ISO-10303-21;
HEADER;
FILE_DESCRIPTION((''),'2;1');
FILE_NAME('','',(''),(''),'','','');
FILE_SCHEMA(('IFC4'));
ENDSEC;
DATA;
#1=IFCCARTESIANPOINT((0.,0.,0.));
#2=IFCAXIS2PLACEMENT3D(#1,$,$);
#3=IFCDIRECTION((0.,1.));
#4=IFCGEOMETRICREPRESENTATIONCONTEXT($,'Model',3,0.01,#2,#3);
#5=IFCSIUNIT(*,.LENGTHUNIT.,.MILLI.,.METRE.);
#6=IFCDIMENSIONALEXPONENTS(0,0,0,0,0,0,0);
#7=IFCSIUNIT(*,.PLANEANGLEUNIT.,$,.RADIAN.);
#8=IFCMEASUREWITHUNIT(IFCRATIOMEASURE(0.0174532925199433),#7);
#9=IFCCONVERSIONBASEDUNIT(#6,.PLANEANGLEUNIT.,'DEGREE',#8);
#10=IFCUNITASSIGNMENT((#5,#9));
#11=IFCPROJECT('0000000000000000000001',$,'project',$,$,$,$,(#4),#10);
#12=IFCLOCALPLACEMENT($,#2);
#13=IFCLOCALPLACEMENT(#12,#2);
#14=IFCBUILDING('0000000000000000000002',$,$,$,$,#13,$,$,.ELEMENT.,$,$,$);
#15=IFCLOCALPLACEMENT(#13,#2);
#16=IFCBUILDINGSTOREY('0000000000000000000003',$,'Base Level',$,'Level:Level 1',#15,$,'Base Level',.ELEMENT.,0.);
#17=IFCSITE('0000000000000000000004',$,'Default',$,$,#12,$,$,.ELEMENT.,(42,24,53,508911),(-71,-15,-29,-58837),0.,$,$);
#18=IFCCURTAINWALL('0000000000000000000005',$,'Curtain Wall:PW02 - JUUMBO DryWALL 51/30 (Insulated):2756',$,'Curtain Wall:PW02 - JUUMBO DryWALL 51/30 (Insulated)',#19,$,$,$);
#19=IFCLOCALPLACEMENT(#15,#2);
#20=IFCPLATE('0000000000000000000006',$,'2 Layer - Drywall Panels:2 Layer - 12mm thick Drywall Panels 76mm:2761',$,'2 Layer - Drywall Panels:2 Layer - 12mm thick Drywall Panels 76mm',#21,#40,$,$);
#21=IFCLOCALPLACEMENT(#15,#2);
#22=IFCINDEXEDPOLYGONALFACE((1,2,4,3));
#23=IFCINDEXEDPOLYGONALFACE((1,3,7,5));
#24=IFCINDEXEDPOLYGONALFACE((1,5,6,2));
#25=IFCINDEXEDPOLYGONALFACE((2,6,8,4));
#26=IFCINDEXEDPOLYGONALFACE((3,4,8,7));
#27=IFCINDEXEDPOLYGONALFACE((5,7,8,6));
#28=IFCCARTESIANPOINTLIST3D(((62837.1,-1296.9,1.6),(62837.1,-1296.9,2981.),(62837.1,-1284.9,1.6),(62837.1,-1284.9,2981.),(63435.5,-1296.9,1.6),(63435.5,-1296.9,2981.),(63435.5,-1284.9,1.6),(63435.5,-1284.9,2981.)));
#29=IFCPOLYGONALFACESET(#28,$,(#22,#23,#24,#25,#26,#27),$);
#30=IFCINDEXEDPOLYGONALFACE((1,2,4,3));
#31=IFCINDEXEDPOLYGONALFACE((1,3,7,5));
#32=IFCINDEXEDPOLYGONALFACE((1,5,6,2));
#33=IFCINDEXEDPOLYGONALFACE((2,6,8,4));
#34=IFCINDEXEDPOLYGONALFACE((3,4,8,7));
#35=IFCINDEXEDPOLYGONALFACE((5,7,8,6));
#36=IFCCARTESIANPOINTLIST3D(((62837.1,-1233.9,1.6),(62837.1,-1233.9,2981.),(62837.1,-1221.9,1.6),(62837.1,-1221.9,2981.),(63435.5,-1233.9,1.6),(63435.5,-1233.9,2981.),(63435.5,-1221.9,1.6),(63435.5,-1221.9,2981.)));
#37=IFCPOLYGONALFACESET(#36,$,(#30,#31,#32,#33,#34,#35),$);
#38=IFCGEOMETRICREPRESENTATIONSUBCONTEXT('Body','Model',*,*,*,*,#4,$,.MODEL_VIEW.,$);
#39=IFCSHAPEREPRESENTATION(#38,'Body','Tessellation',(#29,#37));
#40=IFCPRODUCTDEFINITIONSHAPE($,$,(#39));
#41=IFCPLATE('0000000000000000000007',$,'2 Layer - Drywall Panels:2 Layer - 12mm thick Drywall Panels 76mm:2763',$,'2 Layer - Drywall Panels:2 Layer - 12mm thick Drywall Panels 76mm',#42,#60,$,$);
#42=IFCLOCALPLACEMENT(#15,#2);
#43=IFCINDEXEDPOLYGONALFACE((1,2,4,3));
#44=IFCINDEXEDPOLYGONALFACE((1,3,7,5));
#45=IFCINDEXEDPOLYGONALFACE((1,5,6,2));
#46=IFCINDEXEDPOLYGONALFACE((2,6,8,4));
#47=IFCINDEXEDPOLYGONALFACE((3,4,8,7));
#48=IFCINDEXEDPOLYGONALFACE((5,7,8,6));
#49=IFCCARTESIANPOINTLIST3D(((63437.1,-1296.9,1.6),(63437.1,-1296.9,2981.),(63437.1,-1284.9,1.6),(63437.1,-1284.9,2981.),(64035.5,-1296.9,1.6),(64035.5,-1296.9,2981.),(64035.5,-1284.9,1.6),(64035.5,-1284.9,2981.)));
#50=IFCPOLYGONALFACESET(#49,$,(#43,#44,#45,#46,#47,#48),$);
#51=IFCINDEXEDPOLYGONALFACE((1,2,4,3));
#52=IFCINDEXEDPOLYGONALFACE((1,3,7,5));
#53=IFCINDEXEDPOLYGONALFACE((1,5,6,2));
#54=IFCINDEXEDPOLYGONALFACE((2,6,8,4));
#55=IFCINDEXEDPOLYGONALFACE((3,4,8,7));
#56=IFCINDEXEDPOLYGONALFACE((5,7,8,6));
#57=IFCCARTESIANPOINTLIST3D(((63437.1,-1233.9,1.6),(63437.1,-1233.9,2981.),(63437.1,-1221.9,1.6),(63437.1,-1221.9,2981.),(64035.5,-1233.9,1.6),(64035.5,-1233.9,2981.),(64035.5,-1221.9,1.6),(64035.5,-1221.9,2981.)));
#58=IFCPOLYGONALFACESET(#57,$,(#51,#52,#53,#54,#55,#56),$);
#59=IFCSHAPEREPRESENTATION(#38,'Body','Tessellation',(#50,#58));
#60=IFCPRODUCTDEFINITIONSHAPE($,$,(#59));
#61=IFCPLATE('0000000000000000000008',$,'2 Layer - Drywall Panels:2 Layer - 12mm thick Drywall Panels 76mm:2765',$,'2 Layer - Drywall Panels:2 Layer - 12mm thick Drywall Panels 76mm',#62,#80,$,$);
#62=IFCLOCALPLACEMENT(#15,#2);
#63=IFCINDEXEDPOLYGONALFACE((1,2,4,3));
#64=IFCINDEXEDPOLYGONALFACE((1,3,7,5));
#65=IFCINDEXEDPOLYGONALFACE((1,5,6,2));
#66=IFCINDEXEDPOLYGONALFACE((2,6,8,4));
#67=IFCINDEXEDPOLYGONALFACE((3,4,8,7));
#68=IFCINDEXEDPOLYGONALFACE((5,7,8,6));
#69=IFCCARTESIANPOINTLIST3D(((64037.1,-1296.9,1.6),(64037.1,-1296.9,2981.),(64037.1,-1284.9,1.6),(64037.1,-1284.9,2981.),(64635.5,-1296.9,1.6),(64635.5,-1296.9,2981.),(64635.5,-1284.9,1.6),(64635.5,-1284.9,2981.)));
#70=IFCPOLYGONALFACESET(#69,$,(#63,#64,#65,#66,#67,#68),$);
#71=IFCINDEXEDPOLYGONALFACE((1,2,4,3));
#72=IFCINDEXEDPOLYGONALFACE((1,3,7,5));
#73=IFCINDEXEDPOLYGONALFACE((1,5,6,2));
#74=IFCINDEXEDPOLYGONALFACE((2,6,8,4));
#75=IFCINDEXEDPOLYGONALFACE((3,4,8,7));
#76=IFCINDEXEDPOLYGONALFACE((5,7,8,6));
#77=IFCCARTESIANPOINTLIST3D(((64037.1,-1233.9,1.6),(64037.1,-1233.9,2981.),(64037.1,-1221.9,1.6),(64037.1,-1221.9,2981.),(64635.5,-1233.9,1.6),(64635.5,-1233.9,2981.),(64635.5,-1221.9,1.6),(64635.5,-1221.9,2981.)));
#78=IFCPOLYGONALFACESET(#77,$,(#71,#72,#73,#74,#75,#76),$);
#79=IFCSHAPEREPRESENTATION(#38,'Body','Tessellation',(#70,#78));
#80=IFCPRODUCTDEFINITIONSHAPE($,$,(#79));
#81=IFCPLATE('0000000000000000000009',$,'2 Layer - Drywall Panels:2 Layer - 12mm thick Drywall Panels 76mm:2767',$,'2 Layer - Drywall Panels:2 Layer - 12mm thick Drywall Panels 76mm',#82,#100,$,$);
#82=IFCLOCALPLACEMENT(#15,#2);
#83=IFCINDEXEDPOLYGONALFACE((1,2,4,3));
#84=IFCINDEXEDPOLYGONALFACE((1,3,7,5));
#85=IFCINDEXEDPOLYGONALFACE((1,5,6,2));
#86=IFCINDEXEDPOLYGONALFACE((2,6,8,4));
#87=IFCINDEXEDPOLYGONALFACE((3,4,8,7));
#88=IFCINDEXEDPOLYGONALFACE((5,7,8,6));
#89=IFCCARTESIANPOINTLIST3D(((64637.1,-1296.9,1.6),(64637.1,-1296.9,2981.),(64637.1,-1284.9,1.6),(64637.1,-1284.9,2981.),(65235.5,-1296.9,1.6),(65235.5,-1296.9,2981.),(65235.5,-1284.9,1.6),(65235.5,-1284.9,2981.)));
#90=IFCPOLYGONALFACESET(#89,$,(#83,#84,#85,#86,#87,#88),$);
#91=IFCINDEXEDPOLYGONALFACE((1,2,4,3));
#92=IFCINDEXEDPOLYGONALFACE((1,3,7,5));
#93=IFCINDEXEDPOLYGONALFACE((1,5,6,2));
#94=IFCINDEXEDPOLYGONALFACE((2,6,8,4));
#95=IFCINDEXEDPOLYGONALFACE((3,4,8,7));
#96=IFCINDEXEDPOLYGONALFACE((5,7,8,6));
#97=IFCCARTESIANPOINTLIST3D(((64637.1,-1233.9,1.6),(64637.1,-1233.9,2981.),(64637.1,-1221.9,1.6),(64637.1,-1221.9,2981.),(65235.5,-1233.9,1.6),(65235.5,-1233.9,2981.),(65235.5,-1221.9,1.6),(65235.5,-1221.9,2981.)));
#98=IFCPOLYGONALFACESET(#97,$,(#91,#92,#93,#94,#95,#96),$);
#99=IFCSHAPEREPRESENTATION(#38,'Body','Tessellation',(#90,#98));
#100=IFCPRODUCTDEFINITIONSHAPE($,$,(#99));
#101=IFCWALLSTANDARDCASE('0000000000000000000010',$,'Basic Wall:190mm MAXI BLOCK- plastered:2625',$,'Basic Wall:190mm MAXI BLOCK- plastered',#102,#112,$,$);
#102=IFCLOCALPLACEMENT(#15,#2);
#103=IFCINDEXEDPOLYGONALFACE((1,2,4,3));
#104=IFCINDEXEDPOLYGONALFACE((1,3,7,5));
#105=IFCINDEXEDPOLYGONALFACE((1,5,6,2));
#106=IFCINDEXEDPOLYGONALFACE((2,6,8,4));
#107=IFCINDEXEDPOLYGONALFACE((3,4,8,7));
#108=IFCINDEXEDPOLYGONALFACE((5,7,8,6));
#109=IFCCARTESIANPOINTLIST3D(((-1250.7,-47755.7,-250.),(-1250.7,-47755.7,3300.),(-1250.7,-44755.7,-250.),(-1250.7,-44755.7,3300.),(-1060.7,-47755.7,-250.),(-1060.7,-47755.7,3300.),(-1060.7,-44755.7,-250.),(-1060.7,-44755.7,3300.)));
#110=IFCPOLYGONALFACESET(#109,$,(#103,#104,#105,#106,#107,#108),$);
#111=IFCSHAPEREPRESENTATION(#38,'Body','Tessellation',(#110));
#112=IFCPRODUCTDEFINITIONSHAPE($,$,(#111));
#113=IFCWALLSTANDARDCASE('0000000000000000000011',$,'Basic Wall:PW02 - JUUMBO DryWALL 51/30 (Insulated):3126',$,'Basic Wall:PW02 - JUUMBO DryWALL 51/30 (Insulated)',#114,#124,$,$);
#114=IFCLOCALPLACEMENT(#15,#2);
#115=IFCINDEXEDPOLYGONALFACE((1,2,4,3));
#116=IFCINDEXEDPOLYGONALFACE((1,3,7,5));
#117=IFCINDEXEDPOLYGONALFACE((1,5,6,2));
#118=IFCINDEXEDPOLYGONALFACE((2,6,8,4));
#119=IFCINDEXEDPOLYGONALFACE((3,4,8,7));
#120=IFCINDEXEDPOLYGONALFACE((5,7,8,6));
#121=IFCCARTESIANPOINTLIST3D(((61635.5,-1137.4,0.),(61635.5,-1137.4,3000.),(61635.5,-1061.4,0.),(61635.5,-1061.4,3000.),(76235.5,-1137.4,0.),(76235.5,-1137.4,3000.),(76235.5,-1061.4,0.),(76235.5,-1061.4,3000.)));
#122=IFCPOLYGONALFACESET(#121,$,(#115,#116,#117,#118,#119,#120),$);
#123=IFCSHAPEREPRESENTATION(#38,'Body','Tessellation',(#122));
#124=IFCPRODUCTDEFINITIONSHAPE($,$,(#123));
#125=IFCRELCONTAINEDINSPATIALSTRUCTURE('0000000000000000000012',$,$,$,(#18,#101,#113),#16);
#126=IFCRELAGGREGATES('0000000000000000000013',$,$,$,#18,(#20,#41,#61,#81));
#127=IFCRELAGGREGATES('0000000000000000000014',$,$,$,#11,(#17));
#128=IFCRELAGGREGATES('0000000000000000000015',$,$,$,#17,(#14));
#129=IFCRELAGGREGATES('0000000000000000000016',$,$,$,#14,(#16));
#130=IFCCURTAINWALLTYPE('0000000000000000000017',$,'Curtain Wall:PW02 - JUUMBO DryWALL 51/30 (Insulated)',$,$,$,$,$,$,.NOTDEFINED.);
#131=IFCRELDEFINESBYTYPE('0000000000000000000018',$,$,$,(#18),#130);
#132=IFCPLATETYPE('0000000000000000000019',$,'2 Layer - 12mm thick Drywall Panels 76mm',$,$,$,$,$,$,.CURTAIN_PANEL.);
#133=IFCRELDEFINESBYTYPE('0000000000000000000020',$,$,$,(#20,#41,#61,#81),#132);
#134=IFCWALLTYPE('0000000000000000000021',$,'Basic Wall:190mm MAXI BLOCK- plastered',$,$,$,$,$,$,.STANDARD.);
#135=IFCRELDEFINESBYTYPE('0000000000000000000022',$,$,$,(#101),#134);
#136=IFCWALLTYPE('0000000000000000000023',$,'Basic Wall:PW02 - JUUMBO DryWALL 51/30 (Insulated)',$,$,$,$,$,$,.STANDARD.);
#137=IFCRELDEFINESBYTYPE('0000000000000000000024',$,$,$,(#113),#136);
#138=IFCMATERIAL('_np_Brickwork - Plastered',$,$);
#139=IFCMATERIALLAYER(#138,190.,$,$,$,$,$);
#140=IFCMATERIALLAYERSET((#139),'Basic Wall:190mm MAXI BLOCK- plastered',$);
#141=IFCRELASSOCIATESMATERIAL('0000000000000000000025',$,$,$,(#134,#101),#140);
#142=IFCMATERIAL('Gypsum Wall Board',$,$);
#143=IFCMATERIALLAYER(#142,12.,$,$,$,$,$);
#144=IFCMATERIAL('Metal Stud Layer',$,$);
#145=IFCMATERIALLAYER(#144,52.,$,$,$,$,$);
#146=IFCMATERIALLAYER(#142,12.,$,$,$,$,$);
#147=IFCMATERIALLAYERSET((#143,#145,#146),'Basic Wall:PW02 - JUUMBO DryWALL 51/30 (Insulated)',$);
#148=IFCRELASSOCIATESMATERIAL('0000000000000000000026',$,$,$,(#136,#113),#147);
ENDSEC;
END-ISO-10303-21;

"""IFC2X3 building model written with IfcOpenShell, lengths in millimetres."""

from ifc_helpers import new_model, entity, si_unit, converted_unit, direction, frame, frame_2d, origin, origin_2d_with_axis, place, context, subcontext, project, spatial, rectangle, extrude, source, transform, mapped, material, layer, layer_set, layer_usage, type_object, type_shapes, element, aggregate, save


model = new_model("IFC2X3")

# Units and contexts
model_context = context("Model", 3, precision=0.01, world=origin(), true_north=direction((0.0, 1.0)))
body_context = subcontext(model_context, "Body", "Model", "MODEL_VIEW")
ifc_project = project(units=[si_unit("LENGTHUNIT", "METRE", prefix="MILLI"), converted_unit("PLANEANGLEUNIT", "DEGREE", entity("IfcRatioMeasure", 0.0174532925199433), si_unit("PLANEANGLEUNIT", "RADIAN"), dimensions=[0, 0, 0, 0, 0, 0, 0])], contexts=[model_context])

# Site, building, storey
site_placement = place(None, origin())
site = spatial("IfcSite", under=ifc_project, at=site_placement, Name="Default", CompositionType="ELEMENT", RefLatitude=(42, 24, 53, 508911), RefLongitude=(-71, -15, -29, -58837), RefElevation=0.0)
building_placement = place(site_placement, origin())
building = spatial("IfcBuilding", under=site, at=building_placement, CompositionType="ELEMENT")
storey_placement = place(building_placement, origin())
storey = spatial("IfcBuildingStorey", under=building, at=storey_placement, Name="Base Level", ObjectType="Level:Level 1", LongName="Base Level", CompositionType="ELEMENT", Elevation=0.0)

# Curtain wall, plates
curtain_wall_type = type_object("IfcCurtainWallType", Name="Curtain Wall:PW02 - JUUMBO DryWALL 51/30 (Insulated)", PredefinedType="NOTDEFINED")
curtain_wall_placement = place(building_placement, origin())
curtain_wall = element("IfcCurtainWall", 1, at=curtain_wall_placement, inside=storey, type_object=curtain_wall_type, Name="Curtain Wall:PW02 - JUUMBO DryWALL 51/30 (Insulated):2756", ObjectType="Curtain Wall:PW02 - JUUMBO DryWALL 51/30 (Insulated)")
plate_type_1 = type_object("IfcPlateType", Name="2 Layer - 12mm thick Drywall Panels 76mm", PredefinedType="CURTAIN_PANEL")
shared_shape_1 = source(origin(), body_context, "Body", "SweptSolid", [
    extrude(rectangle(XDim=598.4, YDim=12.0, at=origin_2d_with_axis()), frame((0.0, -31.5, 0.0), z_axis=(0.0, 0.0, 1.0), x_axis=(-1.0, 0.0, 0.0)), (0.0, 0.0, 1.0), 2979.4),
    extrude(rectangle(XDim=12.0, YDim=598.4, at=frame_2d((0.0, 0.0), x_axis=(1.0, 0.0))), frame((0.0, 31.5, 0.0), z_axis=(0.0, 0.0, 1.0), x_axis=(0.0, 1.0, 0.0)), (0.0, 0.0, 1.0), 2979.4),
])
type_shapes(plate_type_1, [shared_shape_1])
plate_1_placement = place(curtain_wall_placement, frame((63136.3, -1259.4, 1.6)))
plate_1 = element("IfcPlate", 2, at=plate_1_placement, type_object=plate_type_1, Name="2 Layer - Drywall Panels:2 Layer - 12mm thick Drywall Panels 76mm:2761", ObjectType="2 Layer - Drywall Panels:2 Layer - 12mm thick Drywall Panels 76mm", context=body_context, shape_type="MappedRepresentation", body=[
    mapped(shared_shape_1, transform((0.0, 0.0, 0.0), scale=1.0)),
])
plate_2_placement = place(curtain_wall_placement, frame((63736.3, -1259.4, 1.6)))
plate_2 = element("IfcPlate", 3, at=plate_2_placement, type_object=plate_type_1, Name="2 Layer - Drywall Panels:2 Layer - 12mm thick Drywall Panels 76mm:2763", ObjectType="2 Layer - Drywall Panels:2 Layer - 12mm thick Drywall Panels 76mm", context=body_context, shape_type="MappedRepresentation", body=[
    mapped(shared_shape_1, transform((0.0, 0.0, 0.0), scale=1.0)),
])
plate_3_placement = place(curtain_wall_placement, frame((64336.3, -1259.4, 1.6)))
plate_3 = element("IfcPlate", 4, at=plate_3_placement, type_object=plate_type_1, Name="2 Layer - Drywall Panels:2 Layer - 12mm thick Drywall Panels 76mm:2765", ObjectType="2 Layer - Drywall Panels:2 Layer - 12mm thick Drywall Panels 76mm", context=body_context, shape_type="MappedRepresentation", body=[
    mapped(shared_shape_1, transform((0.0, 0.0, 0.0), scale=1.0)),
])
plate_4_placement = place(curtain_wall_placement, frame((64936.3, -1259.4, 1.6)))
plate_4 = element("IfcPlate", 5, at=plate_4_placement, type_object=plate_type_1, Name="2 Layer - Drywall Panels:2 Layer - 12mm thick Drywall Panels 76mm:2767", ObjectType="2 Layer - Drywall Panels:2 Layer - 12mm thick Drywall Panels 76mm", context=body_context, shape_type="MappedRepresentation", body=[
    mapped(shared_shape_1, transform((0.0, 0.0, 0.0), scale=1.0)),
])
aggregate(curtain_wall, [plate_1, plate_2, plate_3, plate_4])

# Walls
ifc_material_1 = material(Name="_np_Brickwork - Plastered")
ifc_layer_1 = layer(ifc_material_1, 190.0)
ifc_layer_set_1 = layer_set([ifc_layer_1], Name="Basic Wall:190mm MAXI BLOCK- plastered")
ifc_layer_usage_1 = layer_usage(ifc_layer_set_1, "AXIS2", "NEGATIVE", 95.0)
wall_type_1 = type_object("IfcWallType", Name="Basic Wall:190mm MAXI BLOCK- plastered", PredefinedType="STANDARD", material=ifc_layer_set_1)
wall_1_placement = place(building_placement, frame((-1155.7, -47755.7, -250.0), z_axis=(0.0, 0.0, 1.0), x_axis=(0.0, 1.0, 0.0)))
element("IfcWallStandardCase", 6, at=wall_1_placement, inside=storey, type_object=wall_type_1, material=ifc_layer_usage_1, Name="Basic Wall:190mm MAXI BLOCK- plastered:2625", ObjectType="Basic Wall:190mm MAXI BLOCK- plastered", context=body_context, shape_type="SweptSolid", body=[
    extrude(rectangle(XDim=3000.0, YDim=190.0, at=frame_2d((1500.0, 0.0), x_axis=(-1.0, 0.0))), origin(), (0.0, 0.0, 1.0), 3550.0),
])
ifc_material_2 = material(Name="Gypsum Wall Board")
ifc_layer_2 = layer(ifc_material_2, 12.0)
ifc_material_3 = material(Name="Metal Stud Layer")
ifc_layer_3 = layer(ifc_material_3, 52.0)
ifc_layer_4 = layer(ifc_material_2, 12.0)
ifc_layer_set_2 = layer_set([ifc_layer_2, ifc_layer_3, ifc_layer_4], Name="Basic Wall:PW02 - JUUMBO DryWALL 51/30 (Insulated)")
ifc_layer_usage_2 = layer_usage(ifc_layer_set_2, "AXIS2", "NEGATIVE", 38.0)
wall_type_2 = type_object("IfcWallType", Name="Basic Wall:PW02 - JUUMBO DryWALL 51/30 (Insulated)", PredefinedType="STANDARD", material=ifc_layer_set_2)
wall_2_placement = place(building_placement, frame((61635.5, -1099.4, 0.0)))
element("IfcWallStandardCase", 7, at=wall_2_placement, inside=storey, type_object=wall_type_2, material=ifc_layer_usage_2, Name="Basic Wall:PW02 - JUUMBO DryWALL 51/30 (Insulated):3126", ObjectType="Basic Wall:PW02 - JUUMBO DryWALL 51/30 (Insulated)", context=body_context, shape_type="SweptSolid", body=[
    extrude(rectangle(XDim=14600.0, YDim=76.0, at=frame_2d((7300.0, 0.0), x_axis=(-1.0, 0.0))), origin(), (0.0, 0.0, 1.0), 3000.0),
])

save(model, "model.ifc")
